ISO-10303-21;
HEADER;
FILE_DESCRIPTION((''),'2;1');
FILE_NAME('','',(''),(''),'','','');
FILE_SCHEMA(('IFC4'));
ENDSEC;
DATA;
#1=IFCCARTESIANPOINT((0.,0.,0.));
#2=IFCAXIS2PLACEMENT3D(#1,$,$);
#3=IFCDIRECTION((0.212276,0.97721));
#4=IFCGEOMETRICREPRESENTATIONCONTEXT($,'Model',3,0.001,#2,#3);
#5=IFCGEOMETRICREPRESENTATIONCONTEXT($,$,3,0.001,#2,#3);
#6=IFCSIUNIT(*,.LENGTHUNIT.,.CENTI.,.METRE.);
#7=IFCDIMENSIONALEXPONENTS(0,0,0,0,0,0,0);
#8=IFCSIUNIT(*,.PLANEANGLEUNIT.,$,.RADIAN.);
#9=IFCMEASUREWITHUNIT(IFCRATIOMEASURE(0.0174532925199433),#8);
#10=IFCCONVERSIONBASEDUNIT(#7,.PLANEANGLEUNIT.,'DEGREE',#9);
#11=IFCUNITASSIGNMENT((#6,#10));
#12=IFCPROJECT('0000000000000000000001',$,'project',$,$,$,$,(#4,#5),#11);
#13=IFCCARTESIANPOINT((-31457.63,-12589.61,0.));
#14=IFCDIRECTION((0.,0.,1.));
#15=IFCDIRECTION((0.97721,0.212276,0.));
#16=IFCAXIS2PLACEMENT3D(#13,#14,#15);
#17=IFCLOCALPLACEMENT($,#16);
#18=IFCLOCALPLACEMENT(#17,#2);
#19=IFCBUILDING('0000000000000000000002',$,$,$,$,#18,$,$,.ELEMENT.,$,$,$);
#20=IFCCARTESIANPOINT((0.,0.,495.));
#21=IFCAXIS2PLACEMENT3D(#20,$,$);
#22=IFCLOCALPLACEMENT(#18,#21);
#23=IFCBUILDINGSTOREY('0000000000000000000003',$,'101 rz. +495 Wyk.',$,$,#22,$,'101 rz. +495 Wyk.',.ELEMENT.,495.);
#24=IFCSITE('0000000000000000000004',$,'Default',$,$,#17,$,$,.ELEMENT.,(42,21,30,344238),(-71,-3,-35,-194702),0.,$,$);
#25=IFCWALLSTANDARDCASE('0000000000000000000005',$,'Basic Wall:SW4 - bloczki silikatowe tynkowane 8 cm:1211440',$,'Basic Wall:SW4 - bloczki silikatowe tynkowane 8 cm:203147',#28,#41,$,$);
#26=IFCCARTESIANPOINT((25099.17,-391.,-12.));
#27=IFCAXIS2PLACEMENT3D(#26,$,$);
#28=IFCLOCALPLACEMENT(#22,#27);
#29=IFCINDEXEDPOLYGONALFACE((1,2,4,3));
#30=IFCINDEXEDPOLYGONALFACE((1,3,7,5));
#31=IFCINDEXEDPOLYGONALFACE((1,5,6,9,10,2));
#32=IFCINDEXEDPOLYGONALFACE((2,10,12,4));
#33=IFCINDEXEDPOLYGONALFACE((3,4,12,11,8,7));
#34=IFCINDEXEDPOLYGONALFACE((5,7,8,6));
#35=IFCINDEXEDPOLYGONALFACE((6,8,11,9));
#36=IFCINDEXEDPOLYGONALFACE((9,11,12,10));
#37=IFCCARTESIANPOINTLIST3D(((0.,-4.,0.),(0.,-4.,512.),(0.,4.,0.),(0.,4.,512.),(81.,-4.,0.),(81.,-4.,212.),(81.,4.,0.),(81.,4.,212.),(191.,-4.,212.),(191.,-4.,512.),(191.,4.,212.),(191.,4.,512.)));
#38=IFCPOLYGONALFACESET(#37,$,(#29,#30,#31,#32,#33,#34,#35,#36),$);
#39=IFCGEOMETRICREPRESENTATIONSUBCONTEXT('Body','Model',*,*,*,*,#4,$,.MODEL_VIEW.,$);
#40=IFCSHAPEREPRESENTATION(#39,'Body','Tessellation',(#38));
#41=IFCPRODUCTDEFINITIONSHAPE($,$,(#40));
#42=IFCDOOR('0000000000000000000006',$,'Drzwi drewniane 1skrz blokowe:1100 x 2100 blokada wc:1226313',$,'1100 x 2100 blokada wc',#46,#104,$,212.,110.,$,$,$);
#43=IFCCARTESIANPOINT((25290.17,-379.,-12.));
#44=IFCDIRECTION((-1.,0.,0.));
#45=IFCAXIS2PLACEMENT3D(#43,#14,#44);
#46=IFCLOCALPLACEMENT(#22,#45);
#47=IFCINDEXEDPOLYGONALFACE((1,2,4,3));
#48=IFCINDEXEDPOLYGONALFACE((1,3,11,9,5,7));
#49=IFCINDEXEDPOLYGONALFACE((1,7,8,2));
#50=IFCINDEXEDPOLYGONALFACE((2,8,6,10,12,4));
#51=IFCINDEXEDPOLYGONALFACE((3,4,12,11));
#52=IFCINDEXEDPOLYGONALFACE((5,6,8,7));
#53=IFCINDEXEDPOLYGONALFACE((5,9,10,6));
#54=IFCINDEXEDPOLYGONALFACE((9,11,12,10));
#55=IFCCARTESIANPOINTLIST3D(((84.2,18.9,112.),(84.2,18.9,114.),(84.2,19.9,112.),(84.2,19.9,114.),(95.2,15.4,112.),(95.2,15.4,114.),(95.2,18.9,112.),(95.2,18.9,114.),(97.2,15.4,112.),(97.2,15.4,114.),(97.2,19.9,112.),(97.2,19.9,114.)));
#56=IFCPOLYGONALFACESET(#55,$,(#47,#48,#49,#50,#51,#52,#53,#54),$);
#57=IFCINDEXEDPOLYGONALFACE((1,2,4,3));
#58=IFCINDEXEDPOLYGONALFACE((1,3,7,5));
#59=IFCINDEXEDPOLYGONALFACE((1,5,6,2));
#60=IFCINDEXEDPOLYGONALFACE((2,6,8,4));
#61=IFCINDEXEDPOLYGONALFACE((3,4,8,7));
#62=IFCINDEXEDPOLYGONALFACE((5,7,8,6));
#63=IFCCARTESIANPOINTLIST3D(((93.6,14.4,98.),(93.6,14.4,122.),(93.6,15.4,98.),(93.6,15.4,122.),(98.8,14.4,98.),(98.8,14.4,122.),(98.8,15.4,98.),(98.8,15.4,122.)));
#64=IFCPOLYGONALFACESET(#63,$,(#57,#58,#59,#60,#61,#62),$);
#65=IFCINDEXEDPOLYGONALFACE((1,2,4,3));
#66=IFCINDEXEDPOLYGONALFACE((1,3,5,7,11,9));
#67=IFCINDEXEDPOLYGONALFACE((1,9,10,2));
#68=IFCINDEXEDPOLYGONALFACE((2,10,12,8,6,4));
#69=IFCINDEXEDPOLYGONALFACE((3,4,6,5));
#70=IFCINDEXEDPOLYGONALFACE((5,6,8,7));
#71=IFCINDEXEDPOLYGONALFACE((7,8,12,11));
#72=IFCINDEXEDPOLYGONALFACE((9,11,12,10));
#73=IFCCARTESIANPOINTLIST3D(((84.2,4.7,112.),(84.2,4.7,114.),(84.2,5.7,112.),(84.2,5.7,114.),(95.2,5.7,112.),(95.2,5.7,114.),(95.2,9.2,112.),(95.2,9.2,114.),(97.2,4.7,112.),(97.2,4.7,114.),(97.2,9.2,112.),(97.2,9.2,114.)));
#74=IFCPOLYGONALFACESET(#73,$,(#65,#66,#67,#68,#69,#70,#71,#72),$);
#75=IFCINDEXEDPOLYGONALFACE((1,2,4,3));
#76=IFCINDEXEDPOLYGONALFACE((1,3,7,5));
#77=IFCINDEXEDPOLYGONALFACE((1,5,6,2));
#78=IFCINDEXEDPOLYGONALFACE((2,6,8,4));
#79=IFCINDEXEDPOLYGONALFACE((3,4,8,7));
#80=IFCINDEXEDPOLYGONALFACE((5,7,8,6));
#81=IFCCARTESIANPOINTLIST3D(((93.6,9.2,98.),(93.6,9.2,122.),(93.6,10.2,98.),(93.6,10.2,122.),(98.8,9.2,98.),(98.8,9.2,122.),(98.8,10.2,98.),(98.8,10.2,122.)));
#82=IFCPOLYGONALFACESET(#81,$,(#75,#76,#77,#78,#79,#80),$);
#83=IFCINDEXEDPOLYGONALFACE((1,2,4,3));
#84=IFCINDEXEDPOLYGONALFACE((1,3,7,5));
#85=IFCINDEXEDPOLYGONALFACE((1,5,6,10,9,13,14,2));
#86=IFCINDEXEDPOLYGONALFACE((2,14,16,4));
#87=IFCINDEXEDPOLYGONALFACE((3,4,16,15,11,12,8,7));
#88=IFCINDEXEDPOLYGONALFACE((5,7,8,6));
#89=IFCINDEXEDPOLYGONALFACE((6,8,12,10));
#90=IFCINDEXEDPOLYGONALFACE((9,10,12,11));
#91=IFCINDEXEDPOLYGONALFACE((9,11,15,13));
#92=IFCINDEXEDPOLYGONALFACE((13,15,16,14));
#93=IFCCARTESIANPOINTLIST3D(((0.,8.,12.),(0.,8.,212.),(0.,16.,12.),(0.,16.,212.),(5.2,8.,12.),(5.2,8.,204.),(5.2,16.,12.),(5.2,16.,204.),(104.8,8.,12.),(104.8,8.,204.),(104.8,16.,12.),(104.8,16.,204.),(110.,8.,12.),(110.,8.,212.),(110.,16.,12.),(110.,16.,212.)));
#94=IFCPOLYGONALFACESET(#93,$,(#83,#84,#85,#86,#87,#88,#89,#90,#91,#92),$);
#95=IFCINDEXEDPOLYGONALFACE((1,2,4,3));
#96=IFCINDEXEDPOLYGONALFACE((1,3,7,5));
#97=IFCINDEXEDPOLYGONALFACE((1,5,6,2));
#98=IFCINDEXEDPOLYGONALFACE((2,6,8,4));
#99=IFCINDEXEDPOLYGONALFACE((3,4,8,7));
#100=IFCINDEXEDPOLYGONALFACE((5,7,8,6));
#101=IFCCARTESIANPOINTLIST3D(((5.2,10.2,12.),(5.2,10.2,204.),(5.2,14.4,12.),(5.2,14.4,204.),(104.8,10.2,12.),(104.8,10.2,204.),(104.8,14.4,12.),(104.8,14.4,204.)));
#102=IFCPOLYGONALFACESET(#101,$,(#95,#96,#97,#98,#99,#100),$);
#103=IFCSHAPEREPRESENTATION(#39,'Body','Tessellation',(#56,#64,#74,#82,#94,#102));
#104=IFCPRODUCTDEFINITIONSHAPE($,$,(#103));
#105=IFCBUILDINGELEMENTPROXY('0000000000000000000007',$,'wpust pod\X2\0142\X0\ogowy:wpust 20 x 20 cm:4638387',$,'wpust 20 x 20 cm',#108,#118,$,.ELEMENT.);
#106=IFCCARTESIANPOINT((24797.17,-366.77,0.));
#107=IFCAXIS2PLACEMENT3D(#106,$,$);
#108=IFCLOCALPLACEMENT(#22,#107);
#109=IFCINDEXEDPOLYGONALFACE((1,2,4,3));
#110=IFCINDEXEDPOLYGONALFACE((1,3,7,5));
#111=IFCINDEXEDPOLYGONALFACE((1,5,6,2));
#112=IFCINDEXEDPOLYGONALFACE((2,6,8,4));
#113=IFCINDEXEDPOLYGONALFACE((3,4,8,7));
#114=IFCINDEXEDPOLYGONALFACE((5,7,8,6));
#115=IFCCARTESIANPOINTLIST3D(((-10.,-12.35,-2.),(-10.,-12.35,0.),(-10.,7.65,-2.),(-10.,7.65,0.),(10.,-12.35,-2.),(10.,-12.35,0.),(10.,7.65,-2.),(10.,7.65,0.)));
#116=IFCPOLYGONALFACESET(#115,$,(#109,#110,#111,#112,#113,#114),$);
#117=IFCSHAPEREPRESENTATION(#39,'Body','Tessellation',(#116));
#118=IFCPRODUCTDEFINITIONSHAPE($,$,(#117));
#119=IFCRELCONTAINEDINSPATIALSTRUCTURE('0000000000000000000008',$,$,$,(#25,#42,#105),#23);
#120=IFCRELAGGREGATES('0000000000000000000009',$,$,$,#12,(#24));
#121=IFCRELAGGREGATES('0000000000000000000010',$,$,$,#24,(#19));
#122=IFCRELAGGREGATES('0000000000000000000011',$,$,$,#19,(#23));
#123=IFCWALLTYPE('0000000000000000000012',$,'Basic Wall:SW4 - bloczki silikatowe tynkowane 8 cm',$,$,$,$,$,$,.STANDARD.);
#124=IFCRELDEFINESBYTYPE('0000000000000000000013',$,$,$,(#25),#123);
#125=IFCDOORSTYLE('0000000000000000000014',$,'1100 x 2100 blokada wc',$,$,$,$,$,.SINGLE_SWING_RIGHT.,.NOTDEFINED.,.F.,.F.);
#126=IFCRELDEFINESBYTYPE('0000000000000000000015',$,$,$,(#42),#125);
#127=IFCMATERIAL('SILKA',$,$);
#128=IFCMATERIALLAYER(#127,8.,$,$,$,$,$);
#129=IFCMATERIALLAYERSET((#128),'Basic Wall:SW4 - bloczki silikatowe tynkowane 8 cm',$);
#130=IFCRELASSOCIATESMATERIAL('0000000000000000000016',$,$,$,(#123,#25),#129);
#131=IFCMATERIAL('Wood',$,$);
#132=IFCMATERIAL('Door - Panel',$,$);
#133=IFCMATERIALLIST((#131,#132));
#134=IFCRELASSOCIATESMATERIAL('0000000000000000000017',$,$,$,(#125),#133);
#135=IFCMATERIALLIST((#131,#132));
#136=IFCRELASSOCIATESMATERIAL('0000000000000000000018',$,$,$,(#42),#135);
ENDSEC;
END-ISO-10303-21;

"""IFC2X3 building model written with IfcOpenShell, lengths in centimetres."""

from ifc_helpers import new_model, entity, si_unit, converted_unit, direction, frame, frame_2d, origin, origin_2d_with_axis, place, context, subcontext, project, spatial, polyline, rectangle, outline, extrude, clip, bounded_halfspace, source, transform, mapped, material, material_list, layer, layer_set, layer_usage, type_object, type_shapes, element, fill, save


model = new_model("IFC2X3")

# Units and contexts
model_context = context("Model", 3, precision=0.001, world=origin(), true_north=direction((0.212276, 0.97721)))
context_of_model = context(None, 3, precision=0.001, world=origin(), true_north=direction((0.212276, 0.97721)))
body_context = subcontext(model_context, "Body", "Model", "MODEL_VIEW")
ifc_project = project(units=[si_unit("LENGTHUNIT", "METRE", prefix="CENTI"), converted_unit("PLANEANGLEUNIT", "DEGREE", entity("IfcRatioMeasure", 0.0174532925199433), si_unit("PLANEANGLEUNIT", "RADIAN"), dimensions=[0, 0, 0, 0, 0, 0, 0])], contexts=[model_context, context_of_model])

# Site, building, storey
site_placement = place(None, frame((-31457.63, -12589.61, 0.0), z_axis=(0.0, 0.0, 1.0), x_axis=(0.97721, 0.212276, 0.0)))
site = spatial("IfcSite", under=ifc_project, at=site_placement, Name="Default", CompositionType="ELEMENT", RefLatitude=(42, 21, 30, 344238), RefLongitude=(-71, -3, -35, -194702), RefElevation=0.0)
building_placement = place(site_placement, origin())
building = spatial("IfcBuilding", under=site, at=building_placement, CompositionType="ELEMENT")
storey_placement = place(building_placement, frame((0.0, 0.0, 495.0)))
storey = spatial("IfcBuildingStorey", under=building, at=storey_placement, Name="101 rz. +495 Wyk.", LongName="101 rz. +495 Wyk.", CompositionType="ELEMENT", Elevation=495.0)

# Shared definitions
ifc_material_1 = material(Name="SILKA")

# Shared definitions
ifc_material_2 = material(Name="Door - Panel")
ifc_material_3 = material(Name="Wood")

# Wall, opening, door
ifc_layer_1 = layer(ifc_material_1, 8.0)
ifc_layer_set_1 = layer_set([ifc_layer_1], Name="Basic Wall:SW4 - bloczki silikatowe tynkowane 8 cm")
ifc_layer_usage_1 = layer_usage(ifc_layer_set_1, "AXIS2", "NEGATIVE", 4.0)
wall_type_1 = type_object("IfcWallType", Name="Basic Wall:SW4 - bloczki silikatowe tynkowane 8 cm", PredefinedType="STANDARD", material=ifc_layer_set_1)
wall_1_placement = place(storey_placement, frame((25099.17, -391.0, -12.0)))
wall_1 = element("IfcWallStandardCase", 1, at=wall_1_placement, inside=storey, type_object=wall_type_1, material=ifc_layer_usage_1, Name="Basic Wall:SW4 - bloczki silikatowe tynkowane 8 cm:1211440", ObjectType="Basic Wall:SW4 - bloczki silikatowe tynkowane 8 cm:203147", context=body_context, shape_type="Clipping", body=[
    clip(extrude(rectangle(XDim=191.0, YDim=8.0, at=frame_2d((95.5, 0.0), x_axis=(-1.0, 0.0))), origin(), (0.0, 0.0, 1.0), 537.0), bounded_halfspace(frame((0.0, -4.0, 512.0), z_axis=(0.0, 0.0, -1.0), x_axis=(1.0, 0.0, 0.0)), True, frame((0.0, -4.0, 512.0)), polyline([(0.0, 0.0), (191.0, 0.0), (191.0, 8.0), (0.0, 8.0), (0.0, 0.0)]))),
])
opening_1_placement = place(wall_1_placement, frame((81.0, -4.0, 0.0)))
opening_1 = element("IfcOpeningElement", 2, at=opening_1_placement, cuts=wall_1, ObjectType="Opening", context=body_context, shape_type="SweptSolid", body=[
    extrude(rectangle(XDim=212.0, YDim=110.0, at=frame_2d((0.0, 0.0), x_axis=(0.0, 1.0))), frame((55.0, 0.0, 106.0), z_axis=(0.0, 1.0, 0.0), x_axis=(1.0, 0.0, 0.0)), (0.0, 0.0, 1.0), 8.0),
])
ifc_material_list_1 = material_list([ifc_material_3, ifc_material_2])
ifc_material_list_2 = material_list([ifc_material_3, ifc_material_2])
door_style_1 = type_object("IfcDoorStyle", Name="1100 x 2100 blokada wc", ConstructionType="NOTDEFINED", OperationType="SINGLE_SWING_RIGHT", ParameterTakesPrecedence=False, Sizeable=False, material=ifc_material_list_2)
shared_shape_1 = source(origin(), body_context, "Body", "SweptSolid", [
    extrude(outline(polyline([(-5.0, -1.83), (8.0, -1.83), (8.0, -0.83), (-3.0, -0.83), (-3.0, 2.67), (-5.0, 2.67), (-5.0, -1.83)])), frame((92.2, 18.07, 112.0), z_axis=(0.0, 0.0, 1.0), x_axis=(-1.0, 0.0, 0.0)), (0.0, 0.0, 1.0), 2.0),
    extrude(rectangle(XDim=1.0, YDim=5.2, at=origin_2d_with_axis()), frame((96.2, 14.9, 98.0), z_axis=(0.0, 0.0, 1.0), x_axis=(0.0, -1.0, 0.0)), (0.0, 0.0, 1.0), 24.0),
    extrude(outline(polyline([(-1.83, -5.0), (2.67, -5.0), (2.67, -3.0), (-0.83, -3.0), (-0.83, 8.0), (-1.83, 8.0), (-1.83, -5.0)])), frame((92.2, 6.53, 112.0), z_axis=(0.0, 0.0, 1.0), x_axis=(0.0, 1.0, 0.0)), (0.0, 0.0, 1.0), 2.0),
    extrude(rectangle(XDim=5.2, YDim=1.0, at=origin_2d_with_axis()), frame((96.2, 9.7, 98.0)), (0.0, 0.0, 1.0), 24.0),
    extrude(outline(polyline([(-102.0, -55.0), (98.0, -55.0), (98.0, -49.8), (-94.0, -49.8), (-94.0, 49.8), (98.0, 49.8), (98.0, 55.0), (-102.0, 55.0), (-102.0, -55.0)])), frame((55.0, 16.0, 110.0), z_axis=(0.0, -1.0, 0.0), x_axis=(0.0, 0.0, -1.0)), (0.0, 0.0, 1.0), 8.0),
    extrude(rectangle(XDim=99.6, YDim=4.2, at=frame_2d((0.0, 0.0), x_axis=(1.0, 0.0))), frame((55.0, 12.3, 12.0)), (0.0, 0.0, 1.0), 192.0),
])
type_shapes(door_style_1, [shared_shape_1])
door_1_placement = place(storey_placement, frame((25290.17, -379.0, -12.0), z_axis=(0.0, 0.0, 1.0), x_axis=(-1.0, 0.0, 0.0)))
door_1 = element("IfcDoor", 3, at=door_1_placement, inside=storey, type_object=door_style_1, material=ifc_material_list_1, Name="Drzwi drewniane 1skrz blokowe:1100 x 2100 blokada wc:1226313", ObjectType="1100 x 2100 blokada wc", OverallHeight=212.0, OverallWidth=110.0, context=body_context, shape_type="MappedRepresentation", body=[
    mapped(shared_shape_1, transform((0.0, 0.0, 0.0), scale=1.0)),
])
fill(opening_1, door_1)

# Building element proxy
shared_shape_2 = source(origin(), body_context, "Body", "SweptSolid", [
    extrude(rectangle(XDim=20.0, YDim=20.0, at=frame_2d((0.0, 0.0), x_axis=(1.0, 0.0))), frame((0.0, -2.35, -2.0), z_axis=(0.0, 0.0, 1.0), x_axis=(-1.0, 0.0, 0.0)), (0.0, 0.0, 1.0), 2.0),
])
proxy_placement = place(storey_placement, frame((24797.17, -366.77, 0.0)))
element("IfcBuildingElementProxy", 4, at=proxy_placement, inside=storey, Name="wpust podłogowy:wpust 20 x 20 cm:4638387", ObjectType="wpust 20 x 20 cm", CompositionType="ELEMENT", context=body_context, shape_type="MappedRepresentation", body=[
    mapped(shared_shape_2, transform((0.0, 0.0, 0.0), scale=1.0)),
])

save(model, "model.ifc")
